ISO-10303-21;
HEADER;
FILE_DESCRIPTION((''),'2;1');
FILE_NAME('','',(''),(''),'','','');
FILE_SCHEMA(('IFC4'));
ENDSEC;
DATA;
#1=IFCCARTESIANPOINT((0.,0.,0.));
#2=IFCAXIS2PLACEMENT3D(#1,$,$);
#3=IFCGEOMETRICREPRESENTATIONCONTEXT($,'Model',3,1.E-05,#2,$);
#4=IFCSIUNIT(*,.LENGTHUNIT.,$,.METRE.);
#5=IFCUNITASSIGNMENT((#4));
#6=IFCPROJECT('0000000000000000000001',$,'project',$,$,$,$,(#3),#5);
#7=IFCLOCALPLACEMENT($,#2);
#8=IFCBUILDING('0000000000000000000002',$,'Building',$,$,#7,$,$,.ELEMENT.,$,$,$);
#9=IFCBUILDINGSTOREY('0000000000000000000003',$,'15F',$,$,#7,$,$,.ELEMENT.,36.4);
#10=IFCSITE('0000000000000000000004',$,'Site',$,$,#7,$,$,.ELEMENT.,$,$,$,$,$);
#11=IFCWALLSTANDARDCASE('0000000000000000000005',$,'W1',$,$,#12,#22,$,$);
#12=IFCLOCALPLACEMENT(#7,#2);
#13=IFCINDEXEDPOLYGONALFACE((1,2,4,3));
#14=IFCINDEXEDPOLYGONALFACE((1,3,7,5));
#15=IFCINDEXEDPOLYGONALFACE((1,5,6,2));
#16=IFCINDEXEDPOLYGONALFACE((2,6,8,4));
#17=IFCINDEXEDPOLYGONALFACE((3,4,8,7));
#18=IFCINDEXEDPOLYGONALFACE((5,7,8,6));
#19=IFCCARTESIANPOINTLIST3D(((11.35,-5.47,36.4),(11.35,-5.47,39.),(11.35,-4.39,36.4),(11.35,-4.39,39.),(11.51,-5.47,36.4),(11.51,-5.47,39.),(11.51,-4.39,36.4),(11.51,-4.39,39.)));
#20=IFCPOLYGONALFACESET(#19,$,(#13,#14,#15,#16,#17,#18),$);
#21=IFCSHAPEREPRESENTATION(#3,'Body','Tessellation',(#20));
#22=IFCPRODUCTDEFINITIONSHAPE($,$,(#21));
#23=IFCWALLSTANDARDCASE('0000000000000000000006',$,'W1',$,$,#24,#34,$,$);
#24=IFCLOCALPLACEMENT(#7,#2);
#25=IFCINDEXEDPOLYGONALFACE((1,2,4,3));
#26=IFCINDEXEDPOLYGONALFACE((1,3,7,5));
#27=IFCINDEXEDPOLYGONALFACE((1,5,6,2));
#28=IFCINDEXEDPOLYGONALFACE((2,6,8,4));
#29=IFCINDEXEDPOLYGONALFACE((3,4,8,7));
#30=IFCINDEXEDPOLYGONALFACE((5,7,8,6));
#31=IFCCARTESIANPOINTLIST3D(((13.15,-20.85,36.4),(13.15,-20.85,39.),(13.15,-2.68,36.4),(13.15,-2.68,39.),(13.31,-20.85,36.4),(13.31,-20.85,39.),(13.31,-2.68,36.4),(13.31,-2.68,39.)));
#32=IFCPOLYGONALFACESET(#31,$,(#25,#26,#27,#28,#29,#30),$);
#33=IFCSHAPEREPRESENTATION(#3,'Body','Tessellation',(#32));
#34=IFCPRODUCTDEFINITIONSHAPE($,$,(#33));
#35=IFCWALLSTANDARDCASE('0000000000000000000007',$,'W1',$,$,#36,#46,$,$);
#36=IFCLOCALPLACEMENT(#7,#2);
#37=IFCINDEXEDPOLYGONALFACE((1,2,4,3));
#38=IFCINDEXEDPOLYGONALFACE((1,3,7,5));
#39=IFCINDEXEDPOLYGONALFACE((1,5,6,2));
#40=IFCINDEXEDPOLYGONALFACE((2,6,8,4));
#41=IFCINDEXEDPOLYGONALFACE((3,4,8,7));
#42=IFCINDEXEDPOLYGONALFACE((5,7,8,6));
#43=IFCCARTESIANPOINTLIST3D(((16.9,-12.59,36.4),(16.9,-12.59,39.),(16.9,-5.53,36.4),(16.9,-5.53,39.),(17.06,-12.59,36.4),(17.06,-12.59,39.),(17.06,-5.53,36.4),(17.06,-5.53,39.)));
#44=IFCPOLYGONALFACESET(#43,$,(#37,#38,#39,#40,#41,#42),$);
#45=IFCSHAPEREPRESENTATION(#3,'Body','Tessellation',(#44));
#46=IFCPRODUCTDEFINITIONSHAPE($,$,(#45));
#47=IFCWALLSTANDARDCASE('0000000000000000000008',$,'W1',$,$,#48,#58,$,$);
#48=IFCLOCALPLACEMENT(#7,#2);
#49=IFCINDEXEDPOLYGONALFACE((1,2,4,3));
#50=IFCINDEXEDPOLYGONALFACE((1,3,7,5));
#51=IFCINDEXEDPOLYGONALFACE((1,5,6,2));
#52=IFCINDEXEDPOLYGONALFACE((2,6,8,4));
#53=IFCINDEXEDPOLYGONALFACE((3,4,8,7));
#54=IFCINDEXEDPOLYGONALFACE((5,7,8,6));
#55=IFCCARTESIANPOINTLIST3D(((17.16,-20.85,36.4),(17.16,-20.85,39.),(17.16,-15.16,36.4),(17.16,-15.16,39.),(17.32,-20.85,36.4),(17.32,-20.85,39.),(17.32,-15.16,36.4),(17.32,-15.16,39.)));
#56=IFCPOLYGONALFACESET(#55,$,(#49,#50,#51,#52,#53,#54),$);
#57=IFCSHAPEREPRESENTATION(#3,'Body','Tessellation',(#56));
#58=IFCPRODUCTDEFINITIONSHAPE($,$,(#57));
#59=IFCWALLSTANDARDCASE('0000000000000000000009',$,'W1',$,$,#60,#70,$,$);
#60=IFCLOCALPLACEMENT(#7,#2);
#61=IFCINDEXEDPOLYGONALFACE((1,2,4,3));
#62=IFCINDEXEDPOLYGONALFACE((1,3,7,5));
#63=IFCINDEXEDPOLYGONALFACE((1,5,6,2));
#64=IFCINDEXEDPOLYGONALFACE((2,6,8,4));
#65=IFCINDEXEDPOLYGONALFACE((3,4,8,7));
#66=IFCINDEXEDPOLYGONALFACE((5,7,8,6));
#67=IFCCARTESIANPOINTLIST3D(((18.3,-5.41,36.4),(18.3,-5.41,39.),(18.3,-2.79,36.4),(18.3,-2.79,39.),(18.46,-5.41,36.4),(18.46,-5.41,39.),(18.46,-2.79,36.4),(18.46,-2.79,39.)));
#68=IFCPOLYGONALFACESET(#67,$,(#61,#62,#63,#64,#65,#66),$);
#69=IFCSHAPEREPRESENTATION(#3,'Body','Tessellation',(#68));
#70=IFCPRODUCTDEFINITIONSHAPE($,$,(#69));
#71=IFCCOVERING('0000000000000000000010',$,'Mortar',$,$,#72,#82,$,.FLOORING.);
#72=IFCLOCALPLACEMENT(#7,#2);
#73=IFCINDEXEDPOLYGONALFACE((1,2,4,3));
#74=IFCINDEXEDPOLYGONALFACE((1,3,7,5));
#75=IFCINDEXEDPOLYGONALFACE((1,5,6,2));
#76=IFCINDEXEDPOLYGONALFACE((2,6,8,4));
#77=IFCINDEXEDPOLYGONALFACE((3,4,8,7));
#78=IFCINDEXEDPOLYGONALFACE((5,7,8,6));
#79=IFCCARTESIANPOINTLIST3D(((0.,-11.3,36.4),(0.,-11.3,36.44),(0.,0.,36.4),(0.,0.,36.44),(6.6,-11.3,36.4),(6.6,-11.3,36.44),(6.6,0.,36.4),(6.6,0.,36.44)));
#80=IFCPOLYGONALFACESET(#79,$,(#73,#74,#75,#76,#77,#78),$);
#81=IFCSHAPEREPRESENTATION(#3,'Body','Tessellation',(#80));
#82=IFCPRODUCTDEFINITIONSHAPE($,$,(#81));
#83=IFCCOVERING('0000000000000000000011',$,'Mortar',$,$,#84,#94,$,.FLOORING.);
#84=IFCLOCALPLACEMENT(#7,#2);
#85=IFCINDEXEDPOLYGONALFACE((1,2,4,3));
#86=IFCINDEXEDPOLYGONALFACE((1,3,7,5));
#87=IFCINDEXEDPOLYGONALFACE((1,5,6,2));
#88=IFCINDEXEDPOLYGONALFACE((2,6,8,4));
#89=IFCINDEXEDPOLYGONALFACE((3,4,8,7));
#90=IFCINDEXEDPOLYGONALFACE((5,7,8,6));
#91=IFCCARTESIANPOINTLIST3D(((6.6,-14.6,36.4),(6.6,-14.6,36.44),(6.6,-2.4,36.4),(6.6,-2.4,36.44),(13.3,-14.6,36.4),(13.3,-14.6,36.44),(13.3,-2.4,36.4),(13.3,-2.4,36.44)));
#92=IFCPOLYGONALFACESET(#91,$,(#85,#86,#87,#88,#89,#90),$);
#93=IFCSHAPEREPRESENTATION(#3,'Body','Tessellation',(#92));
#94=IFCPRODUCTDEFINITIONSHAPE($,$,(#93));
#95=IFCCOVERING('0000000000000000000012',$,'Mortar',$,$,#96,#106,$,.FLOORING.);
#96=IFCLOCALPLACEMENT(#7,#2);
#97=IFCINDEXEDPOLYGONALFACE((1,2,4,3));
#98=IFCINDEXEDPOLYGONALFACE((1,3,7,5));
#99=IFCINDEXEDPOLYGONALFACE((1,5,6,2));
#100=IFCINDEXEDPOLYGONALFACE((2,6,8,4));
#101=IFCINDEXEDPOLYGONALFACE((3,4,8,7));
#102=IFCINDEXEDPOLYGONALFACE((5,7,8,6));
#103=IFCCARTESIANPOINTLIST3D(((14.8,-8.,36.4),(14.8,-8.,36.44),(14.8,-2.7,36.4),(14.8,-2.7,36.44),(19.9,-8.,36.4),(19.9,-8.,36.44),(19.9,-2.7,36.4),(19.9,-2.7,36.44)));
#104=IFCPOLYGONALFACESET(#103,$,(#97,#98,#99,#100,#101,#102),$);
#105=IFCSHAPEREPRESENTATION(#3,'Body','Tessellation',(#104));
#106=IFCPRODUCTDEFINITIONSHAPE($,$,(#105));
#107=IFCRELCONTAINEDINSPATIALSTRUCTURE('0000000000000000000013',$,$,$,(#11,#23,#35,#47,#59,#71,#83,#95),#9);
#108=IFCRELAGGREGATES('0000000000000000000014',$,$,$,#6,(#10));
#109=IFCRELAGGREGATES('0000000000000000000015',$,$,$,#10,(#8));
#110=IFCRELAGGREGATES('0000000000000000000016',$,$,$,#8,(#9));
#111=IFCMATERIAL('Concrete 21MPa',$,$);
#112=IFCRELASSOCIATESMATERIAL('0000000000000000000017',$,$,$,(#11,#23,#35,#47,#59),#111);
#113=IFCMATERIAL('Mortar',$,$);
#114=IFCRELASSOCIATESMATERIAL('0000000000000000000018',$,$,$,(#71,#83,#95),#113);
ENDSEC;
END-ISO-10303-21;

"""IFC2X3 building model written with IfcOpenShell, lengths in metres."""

from ifc_helpers import new_model, si_unit, frame, origin, origin_2d, place, context, project, spatial, rectangle, extrude, material, element, save


model = new_model("IFC2X3")

# Units and contexts
model_context = context("Model", 3, precision=1e-05, world=origin())
ifc_project = project(units=[si_unit("LENGTHUNIT", "METRE")], contexts=[model_context])

# Site, building, storey
placement = place(None, origin())
site = spatial("IfcSite", under=ifc_project, at=placement, Name="Site", CompositionType="ELEMENT")
building = spatial("IfcBuilding", under=site, at=placement, Name="Building", CompositionType="ELEMENT")
storey = spatial("IfcBuildingStorey", under=building, at=placement, Name="15F", CompositionType="ELEMENT", Elevation=36.4)

# Shared definitions
ifc_material_1 = material(Name="Concrete 21MPa")

# Walls
wall_1_placement = place(None, frame((11.43, -4.93, 36.4)))
element("IfcWallStandardCase", 1, at=wall_1_placement, inside=storey, material=ifc_material_1, Name="W1", context=model_context, shape_type="SweptSolid", body=[
    extrude(rectangle(XDim=0.16, YDim=1.08, at=origin_2d()), origin(), (0.0, 0.0, 1.0), 2.6),
])
wall_2_placement = place(None, frame((13.23, -11.765, 36.4)))
element("IfcWallStandardCase", 2, at=wall_2_placement, inside=storey, material=ifc_material_1, Name="W1", context=model_context, shape_type="SweptSolid", body=[
    extrude(rectangle(XDim=0.16, YDim=18.17, at=origin_2d()), origin(), (0.0, 0.0, 1.0), 2.6),
])
wall_3_placement = place(None, frame((16.98, -9.06, 36.4)))
element("IfcWallStandardCase", 3, at=wall_3_placement, inside=storey, material=ifc_material_1, Name="W1", context=model_context, shape_type="SweptSolid", body=[
    extrude(rectangle(XDim=0.16, YDim=7.06, at=origin_2d()), origin(), (0.0, 0.0, 1.0), 2.6),
])
wall_4_placement = place(None, frame((17.24, -18.005, 36.4)))
element("IfcWallStandardCase", 4, at=wall_4_placement, inside=storey, material=ifc_material_1, Name="W1", context=model_context, shape_type="SweptSolid", body=[
    extrude(rectangle(XDim=0.16, YDim=5.69, at=origin_2d()), origin(), (0.0, 0.0, 1.0), 2.6),
])
wall_5_placement = place(None, frame((18.38, -4.1, 36.4)))
element("IfcWallStandardCase", 5, at=wall_5_placement, inside=storey, material=ifc_material_1, Name="W1", context=model_context, shape_type="SweptSolid", body=[
    extrude(rectangle(XDim=0.16, YDim=2.62, at=origin_2d()), origin(), (0.0, 0.0, 1.0), 2.6),
])

# Coverings
ifc_material_2 = material(Name="Mortar")
covering_1_placement = place(None, frame((3.3, -5.65, 36.4)))
element("IfcCovering", 6, at=covering_1_placement, inside=storey, material=ifc_material_2, Name="Mortar", PredefinedType="FLOORING", context=model_context, shape_type="SweptSolid", body=[
    extrude(rectangle(XDim=6.6, YDim=11.3, at=origin_2d()), origin(), (0.0, 0.0, 1.0), 0.04),
])
covering_2_placement = place(None, frame((9.95, -8.5, 36.4)))
element("IfcCovering", 7, at=covering_2_placement, inside=storey, material=ifc_material_2, Name="Mortar", PredefinedType="FLOORING", context=model_context, shape_type="SweptSolid", body=[
    extrude(rectangle(XDim=6.7, YDim=12.2, at=origin_2d()), origin(), (0.0, 0.0, 1.0), 0.04),
])
covering_3_placement = place(None, frame((17.35, -5.35, 36.4)))
element("IfcCovering", 8, at=covering_3_placement, inside=storey, material=ifc_material_2, Name="Mortar", PredefinedType="FLOORING", context=model_context, shape_type="SweptSolid", body=[
    extrude(rectangle(XDim=5.1, YDim=5.3, at=origin_2d()), origin(), (0.0, 0.0, 1.0), 0.04),
])

save(model, "model.ifc")
